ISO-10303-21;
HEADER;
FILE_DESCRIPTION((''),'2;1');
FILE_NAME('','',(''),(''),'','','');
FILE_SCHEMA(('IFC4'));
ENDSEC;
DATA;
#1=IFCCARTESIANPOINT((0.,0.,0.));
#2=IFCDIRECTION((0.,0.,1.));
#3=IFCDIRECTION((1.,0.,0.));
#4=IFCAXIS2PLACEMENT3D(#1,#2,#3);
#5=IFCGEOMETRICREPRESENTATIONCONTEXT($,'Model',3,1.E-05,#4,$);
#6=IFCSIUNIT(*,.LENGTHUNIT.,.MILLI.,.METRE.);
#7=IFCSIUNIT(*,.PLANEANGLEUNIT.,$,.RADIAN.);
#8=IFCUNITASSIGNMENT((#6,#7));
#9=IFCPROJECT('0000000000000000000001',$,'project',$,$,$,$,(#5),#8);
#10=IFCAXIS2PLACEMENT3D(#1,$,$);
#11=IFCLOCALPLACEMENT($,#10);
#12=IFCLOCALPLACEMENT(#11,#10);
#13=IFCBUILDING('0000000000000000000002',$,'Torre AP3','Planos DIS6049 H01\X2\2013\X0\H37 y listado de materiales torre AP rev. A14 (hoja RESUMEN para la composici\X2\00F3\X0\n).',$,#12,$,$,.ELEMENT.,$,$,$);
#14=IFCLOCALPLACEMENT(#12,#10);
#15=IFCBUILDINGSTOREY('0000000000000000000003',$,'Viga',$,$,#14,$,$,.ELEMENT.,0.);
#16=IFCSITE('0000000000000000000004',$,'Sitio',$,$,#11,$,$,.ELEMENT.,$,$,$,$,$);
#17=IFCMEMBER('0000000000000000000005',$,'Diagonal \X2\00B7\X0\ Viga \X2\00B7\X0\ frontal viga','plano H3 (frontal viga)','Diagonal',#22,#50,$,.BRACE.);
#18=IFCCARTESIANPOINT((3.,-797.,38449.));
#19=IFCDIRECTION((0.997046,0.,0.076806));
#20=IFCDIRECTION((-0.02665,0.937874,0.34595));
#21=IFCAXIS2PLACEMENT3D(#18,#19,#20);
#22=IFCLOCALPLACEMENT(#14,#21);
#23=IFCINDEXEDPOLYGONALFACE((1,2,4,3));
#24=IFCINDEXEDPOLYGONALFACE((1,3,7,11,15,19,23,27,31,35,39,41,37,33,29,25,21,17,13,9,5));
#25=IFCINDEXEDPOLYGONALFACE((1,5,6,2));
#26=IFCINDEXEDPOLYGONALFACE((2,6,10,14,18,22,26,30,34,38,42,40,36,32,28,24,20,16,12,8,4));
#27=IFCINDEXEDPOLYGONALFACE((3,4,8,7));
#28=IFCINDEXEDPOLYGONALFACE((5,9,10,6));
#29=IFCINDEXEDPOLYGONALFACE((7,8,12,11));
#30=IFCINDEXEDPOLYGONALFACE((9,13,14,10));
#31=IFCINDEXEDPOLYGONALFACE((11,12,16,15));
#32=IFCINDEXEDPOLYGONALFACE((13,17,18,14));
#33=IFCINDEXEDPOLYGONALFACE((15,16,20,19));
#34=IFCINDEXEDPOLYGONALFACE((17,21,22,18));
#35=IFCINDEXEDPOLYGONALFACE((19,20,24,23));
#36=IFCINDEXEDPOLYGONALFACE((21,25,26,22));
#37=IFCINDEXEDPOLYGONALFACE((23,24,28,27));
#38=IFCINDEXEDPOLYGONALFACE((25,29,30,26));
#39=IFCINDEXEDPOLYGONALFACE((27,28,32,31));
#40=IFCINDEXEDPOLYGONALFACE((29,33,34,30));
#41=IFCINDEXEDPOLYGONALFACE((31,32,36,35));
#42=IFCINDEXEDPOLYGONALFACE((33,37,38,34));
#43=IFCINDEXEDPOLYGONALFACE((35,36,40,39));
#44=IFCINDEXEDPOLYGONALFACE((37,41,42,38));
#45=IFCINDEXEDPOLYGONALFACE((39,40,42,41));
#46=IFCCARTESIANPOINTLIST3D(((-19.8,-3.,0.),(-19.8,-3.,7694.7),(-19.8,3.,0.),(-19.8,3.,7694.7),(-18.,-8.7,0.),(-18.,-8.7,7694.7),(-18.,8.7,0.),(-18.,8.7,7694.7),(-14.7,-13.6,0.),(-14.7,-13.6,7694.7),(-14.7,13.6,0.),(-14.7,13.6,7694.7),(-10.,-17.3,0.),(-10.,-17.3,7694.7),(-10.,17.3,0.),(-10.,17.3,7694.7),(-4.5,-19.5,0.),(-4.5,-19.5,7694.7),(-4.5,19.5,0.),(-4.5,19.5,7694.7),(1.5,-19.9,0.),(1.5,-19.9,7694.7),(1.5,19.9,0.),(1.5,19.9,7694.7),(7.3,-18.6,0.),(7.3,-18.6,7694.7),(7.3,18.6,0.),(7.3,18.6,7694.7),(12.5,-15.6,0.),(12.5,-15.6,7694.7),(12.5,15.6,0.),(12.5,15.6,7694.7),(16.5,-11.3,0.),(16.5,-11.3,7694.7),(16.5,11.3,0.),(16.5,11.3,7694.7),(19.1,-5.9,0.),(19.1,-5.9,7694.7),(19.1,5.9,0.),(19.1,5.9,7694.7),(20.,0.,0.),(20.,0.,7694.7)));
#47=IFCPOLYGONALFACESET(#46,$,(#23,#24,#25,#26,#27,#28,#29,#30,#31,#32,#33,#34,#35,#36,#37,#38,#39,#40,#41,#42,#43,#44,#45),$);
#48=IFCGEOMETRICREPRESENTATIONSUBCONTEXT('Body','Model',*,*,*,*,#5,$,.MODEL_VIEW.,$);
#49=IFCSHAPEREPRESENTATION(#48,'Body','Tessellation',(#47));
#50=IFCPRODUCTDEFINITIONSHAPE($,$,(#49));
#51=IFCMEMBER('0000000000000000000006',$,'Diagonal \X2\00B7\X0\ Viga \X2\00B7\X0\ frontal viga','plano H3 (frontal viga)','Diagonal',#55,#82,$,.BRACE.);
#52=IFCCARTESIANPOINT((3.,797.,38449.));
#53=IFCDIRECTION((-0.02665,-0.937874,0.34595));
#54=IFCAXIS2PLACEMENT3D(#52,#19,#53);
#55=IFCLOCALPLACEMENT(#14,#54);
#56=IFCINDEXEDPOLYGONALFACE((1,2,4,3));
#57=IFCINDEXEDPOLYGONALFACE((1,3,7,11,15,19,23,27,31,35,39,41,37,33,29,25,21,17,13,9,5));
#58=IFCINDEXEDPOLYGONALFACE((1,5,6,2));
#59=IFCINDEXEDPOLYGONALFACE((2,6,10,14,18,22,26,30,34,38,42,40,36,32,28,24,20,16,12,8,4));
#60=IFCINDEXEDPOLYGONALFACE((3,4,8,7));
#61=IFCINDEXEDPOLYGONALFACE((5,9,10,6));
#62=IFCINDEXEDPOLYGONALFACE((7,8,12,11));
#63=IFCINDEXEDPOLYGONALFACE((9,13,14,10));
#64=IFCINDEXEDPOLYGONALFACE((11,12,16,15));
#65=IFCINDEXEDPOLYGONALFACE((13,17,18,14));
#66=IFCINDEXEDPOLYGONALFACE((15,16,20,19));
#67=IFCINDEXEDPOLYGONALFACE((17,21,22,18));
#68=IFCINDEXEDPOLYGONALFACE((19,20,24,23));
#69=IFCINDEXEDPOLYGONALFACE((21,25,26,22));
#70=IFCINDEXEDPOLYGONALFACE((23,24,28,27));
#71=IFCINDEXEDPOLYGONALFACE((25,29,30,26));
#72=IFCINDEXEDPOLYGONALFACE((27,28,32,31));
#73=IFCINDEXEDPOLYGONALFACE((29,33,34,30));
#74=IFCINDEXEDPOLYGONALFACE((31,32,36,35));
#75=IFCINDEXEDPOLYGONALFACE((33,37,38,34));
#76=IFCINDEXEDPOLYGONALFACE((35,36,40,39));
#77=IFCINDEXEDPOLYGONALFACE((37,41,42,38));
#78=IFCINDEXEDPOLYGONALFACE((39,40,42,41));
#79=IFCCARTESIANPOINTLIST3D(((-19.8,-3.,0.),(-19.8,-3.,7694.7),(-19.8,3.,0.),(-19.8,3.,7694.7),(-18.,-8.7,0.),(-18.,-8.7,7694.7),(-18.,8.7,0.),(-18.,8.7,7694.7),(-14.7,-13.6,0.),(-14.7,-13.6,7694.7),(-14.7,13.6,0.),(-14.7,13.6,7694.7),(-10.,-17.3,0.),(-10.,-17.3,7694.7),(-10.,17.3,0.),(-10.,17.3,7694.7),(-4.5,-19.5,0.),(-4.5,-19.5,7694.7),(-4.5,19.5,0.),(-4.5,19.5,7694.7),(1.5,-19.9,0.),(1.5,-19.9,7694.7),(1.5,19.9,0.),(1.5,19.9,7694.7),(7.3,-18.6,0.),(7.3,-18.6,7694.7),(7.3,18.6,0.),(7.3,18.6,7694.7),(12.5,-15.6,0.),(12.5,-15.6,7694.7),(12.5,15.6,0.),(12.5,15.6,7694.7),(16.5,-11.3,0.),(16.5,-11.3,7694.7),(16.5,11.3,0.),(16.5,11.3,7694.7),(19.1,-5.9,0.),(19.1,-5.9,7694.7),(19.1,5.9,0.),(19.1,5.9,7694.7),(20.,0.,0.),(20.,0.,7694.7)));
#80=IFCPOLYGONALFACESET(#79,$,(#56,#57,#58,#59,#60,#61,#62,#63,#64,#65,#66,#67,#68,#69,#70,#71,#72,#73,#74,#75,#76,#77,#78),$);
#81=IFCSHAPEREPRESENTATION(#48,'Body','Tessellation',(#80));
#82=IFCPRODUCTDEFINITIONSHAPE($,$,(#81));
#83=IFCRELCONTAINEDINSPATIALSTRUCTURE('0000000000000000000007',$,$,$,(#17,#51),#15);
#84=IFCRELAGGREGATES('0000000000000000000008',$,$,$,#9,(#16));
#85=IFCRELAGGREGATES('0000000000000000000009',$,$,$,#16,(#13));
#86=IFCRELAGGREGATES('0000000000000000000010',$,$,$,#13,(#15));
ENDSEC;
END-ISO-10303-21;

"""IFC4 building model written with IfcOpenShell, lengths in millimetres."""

from ifc_helpers import new_model, si_unit, frame, origin, origin_with_axes, place, context, subcontext, project, spatial, circle, extrude, element, save


model = new_model("IFC4")

# Units and contexts
model_context = context("Model", 3, precision=1e-05, world=origin_with_axes())
body_context = subcontext(model_context, "Body", "Model", "MODEL_VIEW")
ifc_project = project(units=[si_unit("LENGTHUNIT", "METRE", prefix="MILLI"), si_unit("PLANEANGLEUNIT", "RADIAN")], contexts=[model_context])

# Site, building, storey
site_placement = place(None, origin())
site = spatial("IfcSite", under=ifc_project, at=site_placement, Name="Sitio", CompositionType="ELEMENT")
building_placement = place(site_placement, origin())
building = spatial("IfcBuilding", under=site, at=building_placement, Name="Torre AP3", Description="Planos DIS6049 H01–H37 y listado de materiales torre AP rev. A14 (hoja RESUMEN para la composición).", CompositionType="ELEMENT")
storey_placement = place(building_placement, origin())
storey = spatial("IfcBuildingStorey", under=building, at=storey_placement, Name="Viga", CompositionType="ELEMENT", Elevation=0.0)

# Members
for number, where, z_axis, x_axis, name in (
    (1, (3.0, -797.0, 38449.0), (0.997046, 0.0, 0.076806), (-0.02665, 0.937874, 0.34595), "Diagonal · Viga · frontal viga"),
    (2, (3.0, 797.0, 38449.0), (0.997046, 0.0, 0.076806), (-0.02665, -0.937874, 0.34595), "Diagonal · Viga · frontal viga"),
):
    element("IfcMember", number, at=place(storey_placement, frame(where, z_axis=z_axis, x_axis=x_axis)), inside=storey, Name=name, Description="plano H3 (frontal viga)", ObjectType="Diagonal", PredefinedType="BRACE", context=body_context, shape_type="SweptSolid", body=[
        extrude(circle(Radius=20.0), None, (0.0, 0.0, 1.0), 7694.7),
    ])

save(model, "model.ifc")
